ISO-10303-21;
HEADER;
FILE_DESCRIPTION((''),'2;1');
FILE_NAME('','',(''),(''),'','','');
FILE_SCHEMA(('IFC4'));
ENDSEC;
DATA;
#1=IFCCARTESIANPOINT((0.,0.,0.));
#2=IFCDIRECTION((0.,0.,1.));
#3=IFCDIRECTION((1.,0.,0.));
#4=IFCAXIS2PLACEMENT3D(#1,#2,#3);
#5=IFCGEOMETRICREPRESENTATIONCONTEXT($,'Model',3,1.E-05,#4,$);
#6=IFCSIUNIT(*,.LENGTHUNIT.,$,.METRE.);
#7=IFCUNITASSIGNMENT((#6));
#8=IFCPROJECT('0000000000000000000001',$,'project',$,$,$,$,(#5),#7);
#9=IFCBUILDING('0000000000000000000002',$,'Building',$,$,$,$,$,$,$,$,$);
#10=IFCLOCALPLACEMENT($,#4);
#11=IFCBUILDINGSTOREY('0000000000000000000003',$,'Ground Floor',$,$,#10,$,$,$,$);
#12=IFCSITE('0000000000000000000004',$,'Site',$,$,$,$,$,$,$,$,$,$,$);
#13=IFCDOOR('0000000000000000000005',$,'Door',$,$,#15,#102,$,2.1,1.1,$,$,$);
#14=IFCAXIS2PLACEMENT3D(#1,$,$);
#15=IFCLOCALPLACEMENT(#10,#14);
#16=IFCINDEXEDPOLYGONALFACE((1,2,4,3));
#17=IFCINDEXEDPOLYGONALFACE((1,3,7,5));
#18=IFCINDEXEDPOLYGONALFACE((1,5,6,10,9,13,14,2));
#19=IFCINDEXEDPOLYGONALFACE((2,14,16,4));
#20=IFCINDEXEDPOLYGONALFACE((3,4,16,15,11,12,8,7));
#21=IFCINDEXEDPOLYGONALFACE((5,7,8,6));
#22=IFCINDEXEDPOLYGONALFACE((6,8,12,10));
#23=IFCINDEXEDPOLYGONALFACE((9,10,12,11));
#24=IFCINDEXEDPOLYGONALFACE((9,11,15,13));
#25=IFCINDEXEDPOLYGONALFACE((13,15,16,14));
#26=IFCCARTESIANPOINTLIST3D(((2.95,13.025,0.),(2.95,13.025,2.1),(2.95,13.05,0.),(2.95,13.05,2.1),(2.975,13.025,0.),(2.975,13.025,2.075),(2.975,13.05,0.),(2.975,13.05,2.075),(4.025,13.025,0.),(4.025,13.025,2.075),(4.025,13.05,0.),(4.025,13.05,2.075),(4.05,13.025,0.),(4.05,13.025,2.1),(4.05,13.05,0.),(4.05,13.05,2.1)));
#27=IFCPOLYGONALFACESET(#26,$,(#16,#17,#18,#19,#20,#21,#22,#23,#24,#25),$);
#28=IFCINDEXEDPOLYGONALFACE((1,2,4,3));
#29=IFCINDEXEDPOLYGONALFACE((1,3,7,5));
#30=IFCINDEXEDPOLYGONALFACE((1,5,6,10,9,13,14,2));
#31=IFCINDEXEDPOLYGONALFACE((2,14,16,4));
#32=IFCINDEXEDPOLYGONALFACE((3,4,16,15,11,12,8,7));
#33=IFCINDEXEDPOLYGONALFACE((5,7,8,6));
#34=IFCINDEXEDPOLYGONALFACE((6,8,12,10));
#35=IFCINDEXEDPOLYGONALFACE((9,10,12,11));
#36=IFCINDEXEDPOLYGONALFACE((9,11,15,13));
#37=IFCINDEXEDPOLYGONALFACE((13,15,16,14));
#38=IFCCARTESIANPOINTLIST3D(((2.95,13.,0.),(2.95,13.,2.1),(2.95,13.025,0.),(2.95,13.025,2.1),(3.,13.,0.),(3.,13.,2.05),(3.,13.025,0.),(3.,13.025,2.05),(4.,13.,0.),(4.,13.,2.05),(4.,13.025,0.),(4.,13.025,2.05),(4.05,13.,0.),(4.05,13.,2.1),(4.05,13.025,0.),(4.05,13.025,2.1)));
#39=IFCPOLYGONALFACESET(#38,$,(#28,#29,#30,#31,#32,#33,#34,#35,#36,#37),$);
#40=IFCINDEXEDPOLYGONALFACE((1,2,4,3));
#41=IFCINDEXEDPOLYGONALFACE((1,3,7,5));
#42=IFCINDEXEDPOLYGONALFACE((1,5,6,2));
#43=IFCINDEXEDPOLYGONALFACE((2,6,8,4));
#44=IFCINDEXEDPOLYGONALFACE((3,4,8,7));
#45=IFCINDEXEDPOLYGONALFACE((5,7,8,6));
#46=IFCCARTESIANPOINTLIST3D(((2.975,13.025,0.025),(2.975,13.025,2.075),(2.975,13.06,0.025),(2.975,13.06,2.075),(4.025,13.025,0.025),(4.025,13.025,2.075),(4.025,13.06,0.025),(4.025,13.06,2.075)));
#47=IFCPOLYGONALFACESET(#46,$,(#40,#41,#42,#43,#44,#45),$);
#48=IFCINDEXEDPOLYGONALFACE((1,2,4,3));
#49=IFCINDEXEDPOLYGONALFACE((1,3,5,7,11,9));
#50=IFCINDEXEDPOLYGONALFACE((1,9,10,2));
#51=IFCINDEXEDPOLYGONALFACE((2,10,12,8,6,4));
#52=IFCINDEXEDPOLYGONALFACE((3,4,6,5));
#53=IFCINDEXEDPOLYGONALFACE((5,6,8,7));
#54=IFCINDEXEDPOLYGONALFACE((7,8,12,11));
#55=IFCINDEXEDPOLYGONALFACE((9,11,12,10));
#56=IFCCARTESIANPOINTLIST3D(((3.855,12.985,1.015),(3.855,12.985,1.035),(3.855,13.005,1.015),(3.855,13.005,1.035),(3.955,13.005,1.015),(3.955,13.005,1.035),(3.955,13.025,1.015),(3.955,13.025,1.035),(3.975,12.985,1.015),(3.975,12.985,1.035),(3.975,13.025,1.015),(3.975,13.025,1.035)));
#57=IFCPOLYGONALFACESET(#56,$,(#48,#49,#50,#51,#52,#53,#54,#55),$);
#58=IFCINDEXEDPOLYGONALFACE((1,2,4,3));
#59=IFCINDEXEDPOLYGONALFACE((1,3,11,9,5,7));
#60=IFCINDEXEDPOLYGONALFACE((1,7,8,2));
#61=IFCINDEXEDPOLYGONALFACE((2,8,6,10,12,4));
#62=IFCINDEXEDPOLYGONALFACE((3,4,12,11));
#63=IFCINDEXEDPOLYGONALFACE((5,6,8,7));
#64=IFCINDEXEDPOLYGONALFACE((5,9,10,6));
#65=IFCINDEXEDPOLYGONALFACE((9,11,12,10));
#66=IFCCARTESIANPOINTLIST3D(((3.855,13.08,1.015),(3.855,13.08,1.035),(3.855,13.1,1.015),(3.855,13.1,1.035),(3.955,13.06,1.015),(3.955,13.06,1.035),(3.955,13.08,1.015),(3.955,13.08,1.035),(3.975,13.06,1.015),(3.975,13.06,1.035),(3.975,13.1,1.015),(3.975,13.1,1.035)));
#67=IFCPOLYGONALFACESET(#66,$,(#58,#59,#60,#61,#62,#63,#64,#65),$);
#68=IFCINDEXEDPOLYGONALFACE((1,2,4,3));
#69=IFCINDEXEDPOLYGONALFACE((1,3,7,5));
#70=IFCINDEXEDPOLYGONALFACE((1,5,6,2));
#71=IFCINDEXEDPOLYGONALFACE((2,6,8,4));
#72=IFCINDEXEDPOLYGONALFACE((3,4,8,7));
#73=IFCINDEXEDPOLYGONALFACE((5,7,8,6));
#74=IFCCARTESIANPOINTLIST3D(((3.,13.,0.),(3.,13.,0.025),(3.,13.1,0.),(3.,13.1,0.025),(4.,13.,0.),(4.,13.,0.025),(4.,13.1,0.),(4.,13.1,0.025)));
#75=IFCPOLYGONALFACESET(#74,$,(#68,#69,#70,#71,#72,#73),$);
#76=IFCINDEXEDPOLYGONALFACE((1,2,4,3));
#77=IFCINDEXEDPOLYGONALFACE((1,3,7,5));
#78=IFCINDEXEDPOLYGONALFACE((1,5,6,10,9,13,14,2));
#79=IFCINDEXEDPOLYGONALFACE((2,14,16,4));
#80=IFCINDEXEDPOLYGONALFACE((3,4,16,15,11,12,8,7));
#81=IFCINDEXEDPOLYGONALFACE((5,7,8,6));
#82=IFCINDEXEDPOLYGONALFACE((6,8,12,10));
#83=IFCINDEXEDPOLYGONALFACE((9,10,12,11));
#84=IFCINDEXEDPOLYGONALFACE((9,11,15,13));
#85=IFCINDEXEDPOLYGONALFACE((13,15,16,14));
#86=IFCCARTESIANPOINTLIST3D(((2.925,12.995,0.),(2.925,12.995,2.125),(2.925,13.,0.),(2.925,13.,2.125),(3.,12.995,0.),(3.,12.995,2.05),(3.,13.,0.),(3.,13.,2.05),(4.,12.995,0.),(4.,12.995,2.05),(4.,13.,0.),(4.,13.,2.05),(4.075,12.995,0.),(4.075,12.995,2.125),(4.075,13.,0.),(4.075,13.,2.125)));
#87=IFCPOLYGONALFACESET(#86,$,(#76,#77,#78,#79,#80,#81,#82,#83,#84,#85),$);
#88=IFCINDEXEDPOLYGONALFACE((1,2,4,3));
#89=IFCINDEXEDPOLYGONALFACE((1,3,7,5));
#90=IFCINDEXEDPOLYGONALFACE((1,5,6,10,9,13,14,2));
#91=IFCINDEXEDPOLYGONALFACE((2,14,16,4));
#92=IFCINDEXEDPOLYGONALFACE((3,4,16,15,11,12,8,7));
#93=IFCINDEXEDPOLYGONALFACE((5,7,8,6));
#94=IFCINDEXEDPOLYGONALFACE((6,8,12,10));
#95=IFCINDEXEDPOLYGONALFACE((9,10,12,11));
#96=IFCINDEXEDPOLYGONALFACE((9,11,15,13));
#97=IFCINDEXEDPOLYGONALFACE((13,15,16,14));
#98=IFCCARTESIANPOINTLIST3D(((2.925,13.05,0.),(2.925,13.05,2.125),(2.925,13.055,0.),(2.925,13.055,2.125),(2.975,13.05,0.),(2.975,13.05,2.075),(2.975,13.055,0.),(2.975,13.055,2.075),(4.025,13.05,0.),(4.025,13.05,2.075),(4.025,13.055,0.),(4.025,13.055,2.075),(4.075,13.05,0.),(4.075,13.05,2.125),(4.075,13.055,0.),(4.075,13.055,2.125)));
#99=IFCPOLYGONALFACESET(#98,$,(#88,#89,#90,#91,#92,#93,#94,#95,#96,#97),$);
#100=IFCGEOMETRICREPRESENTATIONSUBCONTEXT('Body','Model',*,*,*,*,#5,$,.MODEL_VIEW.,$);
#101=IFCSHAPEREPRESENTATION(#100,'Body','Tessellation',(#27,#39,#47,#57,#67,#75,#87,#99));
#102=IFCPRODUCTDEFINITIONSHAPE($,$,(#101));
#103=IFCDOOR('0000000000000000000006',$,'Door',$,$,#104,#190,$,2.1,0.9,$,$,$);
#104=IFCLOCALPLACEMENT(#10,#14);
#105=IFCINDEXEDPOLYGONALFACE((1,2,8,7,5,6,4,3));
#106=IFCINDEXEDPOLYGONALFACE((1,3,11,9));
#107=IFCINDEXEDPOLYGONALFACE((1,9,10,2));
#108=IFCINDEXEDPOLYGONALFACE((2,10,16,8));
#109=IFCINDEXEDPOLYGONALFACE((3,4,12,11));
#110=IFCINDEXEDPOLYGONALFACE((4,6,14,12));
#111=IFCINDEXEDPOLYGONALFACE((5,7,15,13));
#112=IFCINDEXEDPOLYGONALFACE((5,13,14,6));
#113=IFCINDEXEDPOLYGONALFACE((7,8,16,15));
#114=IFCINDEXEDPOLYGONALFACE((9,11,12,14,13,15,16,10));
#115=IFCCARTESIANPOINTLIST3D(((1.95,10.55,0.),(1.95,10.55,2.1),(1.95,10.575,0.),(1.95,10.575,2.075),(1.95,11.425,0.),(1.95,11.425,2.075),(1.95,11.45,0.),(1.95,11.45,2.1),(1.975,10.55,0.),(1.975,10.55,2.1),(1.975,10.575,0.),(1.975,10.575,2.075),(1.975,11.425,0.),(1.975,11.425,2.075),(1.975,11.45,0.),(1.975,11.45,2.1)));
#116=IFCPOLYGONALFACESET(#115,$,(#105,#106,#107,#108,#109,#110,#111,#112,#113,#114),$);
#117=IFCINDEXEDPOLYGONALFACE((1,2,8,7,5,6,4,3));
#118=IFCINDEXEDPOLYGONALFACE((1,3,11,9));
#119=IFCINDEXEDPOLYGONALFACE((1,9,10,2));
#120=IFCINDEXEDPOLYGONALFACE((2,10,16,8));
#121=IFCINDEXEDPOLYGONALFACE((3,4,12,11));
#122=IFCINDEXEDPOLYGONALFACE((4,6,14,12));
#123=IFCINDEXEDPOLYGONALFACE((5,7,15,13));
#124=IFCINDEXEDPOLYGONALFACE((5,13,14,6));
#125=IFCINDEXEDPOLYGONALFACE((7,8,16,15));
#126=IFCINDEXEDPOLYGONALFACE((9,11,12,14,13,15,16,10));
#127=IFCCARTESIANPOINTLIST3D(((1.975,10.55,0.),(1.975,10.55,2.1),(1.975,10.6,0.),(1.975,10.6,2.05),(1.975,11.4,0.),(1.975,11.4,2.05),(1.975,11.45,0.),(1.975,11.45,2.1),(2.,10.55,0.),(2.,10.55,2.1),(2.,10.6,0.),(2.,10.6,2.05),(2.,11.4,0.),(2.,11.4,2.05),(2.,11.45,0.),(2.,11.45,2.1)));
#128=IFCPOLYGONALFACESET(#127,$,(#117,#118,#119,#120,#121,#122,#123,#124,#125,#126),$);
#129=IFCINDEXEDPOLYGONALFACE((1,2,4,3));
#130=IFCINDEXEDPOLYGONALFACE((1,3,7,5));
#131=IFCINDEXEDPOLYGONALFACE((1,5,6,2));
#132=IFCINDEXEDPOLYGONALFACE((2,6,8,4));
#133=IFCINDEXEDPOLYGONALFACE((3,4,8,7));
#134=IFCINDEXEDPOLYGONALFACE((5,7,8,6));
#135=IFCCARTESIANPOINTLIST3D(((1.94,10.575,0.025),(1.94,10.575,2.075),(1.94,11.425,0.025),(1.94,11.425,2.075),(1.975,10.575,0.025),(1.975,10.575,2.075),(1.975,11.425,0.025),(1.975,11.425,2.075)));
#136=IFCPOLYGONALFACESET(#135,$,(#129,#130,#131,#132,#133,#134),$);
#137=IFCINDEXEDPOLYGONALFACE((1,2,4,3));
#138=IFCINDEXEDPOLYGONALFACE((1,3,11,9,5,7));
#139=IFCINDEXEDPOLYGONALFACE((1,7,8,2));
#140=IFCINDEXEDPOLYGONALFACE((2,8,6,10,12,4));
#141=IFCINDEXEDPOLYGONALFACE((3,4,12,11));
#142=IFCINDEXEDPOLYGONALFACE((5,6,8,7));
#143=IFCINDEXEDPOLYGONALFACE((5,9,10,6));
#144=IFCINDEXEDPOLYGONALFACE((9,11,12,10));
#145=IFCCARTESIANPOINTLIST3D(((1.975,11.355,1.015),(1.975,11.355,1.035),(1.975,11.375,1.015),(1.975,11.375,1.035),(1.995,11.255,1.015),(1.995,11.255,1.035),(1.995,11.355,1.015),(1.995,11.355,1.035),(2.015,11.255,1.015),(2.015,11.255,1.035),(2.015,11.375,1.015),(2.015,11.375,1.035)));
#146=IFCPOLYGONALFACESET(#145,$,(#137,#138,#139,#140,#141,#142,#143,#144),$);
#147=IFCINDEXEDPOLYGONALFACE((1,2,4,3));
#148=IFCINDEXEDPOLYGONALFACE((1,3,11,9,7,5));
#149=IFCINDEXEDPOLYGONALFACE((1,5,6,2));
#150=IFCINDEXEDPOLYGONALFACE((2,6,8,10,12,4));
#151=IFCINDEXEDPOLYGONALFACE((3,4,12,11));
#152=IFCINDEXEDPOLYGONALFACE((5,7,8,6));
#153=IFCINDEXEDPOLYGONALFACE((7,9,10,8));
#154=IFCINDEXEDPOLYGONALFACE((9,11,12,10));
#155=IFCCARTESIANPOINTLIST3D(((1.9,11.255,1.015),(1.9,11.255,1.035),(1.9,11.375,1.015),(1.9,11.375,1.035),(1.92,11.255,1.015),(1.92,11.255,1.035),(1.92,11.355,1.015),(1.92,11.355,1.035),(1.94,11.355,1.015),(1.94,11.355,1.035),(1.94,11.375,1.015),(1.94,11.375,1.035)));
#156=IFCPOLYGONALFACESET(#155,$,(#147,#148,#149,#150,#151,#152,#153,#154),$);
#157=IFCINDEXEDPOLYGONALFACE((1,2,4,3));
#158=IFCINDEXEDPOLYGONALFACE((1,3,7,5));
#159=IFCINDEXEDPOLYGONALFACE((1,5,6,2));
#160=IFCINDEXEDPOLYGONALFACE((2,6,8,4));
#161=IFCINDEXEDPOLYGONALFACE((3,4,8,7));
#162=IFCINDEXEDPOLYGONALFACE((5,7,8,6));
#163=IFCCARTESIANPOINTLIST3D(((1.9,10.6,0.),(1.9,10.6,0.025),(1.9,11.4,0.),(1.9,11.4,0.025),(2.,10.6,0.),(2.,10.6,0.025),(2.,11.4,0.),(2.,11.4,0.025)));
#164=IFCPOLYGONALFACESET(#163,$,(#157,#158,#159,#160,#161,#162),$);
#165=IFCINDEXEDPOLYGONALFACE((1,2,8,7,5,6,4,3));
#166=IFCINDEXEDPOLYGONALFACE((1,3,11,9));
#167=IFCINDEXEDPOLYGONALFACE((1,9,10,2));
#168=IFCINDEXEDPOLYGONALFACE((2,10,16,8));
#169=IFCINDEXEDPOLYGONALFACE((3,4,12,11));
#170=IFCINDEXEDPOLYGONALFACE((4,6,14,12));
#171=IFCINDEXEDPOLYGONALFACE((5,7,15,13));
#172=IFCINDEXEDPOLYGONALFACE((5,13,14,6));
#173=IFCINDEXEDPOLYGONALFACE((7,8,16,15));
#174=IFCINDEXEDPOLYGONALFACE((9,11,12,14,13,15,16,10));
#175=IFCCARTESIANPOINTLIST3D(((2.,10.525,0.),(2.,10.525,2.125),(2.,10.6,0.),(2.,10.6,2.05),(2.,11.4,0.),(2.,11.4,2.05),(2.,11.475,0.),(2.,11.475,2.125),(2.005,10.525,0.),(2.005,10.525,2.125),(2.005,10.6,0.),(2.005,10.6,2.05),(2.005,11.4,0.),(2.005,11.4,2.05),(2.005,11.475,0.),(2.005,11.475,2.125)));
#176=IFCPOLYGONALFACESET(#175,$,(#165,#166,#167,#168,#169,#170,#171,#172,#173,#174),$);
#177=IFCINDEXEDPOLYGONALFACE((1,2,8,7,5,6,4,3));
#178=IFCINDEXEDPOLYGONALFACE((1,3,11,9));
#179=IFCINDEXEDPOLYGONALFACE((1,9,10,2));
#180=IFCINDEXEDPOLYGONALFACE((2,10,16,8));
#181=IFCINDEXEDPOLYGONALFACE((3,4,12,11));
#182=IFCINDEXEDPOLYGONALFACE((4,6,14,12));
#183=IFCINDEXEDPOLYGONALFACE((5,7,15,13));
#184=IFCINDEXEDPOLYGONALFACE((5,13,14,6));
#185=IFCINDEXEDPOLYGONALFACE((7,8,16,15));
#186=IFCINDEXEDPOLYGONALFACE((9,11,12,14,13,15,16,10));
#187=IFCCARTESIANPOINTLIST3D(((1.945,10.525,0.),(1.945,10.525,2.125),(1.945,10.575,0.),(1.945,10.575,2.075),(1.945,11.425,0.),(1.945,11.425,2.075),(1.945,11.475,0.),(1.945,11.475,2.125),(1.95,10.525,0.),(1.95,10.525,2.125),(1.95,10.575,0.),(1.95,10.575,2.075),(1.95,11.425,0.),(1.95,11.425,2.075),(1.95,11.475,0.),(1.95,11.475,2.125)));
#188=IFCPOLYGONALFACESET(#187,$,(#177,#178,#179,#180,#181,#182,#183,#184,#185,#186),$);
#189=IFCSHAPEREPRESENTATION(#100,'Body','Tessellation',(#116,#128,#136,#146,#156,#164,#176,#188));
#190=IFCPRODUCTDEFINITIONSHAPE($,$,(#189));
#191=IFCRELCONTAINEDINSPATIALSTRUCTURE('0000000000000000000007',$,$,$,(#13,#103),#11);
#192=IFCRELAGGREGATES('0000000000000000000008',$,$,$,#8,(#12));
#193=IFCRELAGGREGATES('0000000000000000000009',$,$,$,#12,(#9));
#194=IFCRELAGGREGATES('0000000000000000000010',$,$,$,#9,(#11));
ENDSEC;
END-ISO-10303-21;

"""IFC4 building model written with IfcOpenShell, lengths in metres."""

from ifc_helpers import new_model, si_unit, frame, origin_with_axes, place, context, subcontext, project, spatial, line, indexed_curve, outline, extrude, element, save


model = new_model("IFC4")

# Units and contexts
model_context = context("Model", 3, precision=1e-05, world=origin_with_axes())
body_context = subcontext(model_context, "Body", "Model", "MODEL_VIEW")
ifc_project = project(units=[si_unit("LENGTHUNIT", "METRE")], contexts=[model_context])

# Site, building, storey
site = spatial("IfcSite", under=ifc_project, Name="Site")
building = spatial("IfcBuilding", under=site, Name="Building")
storey_placement = place(None, origin_with_axes())
storey = spatial("IfcBuildingStorey", under=building, at=storey_placement, Name="Ground Floor")

# Doors
door_1_placement = place(storey_placement, frame((2.95, 13.0, 0.0), z_axis=(0.0, 0.0, 1.0), x_axis=(1.0, 0.0, 0.0)))
element("IfcDoor", 1, at=door_1_placement, inside=storey, Name="Door", OverallHeight=2.1, OverallWidth=1.1, context=body_context, shape_type="SweptSolid", body=[
    extrude(outline(indexed_curve([(0.0, 0.0), (0.0, 2.1), (1.1, 2.1), (1.1, 0.0), (1.075, 0.0), (1.075, 2.075), (0.025, 2.075), (0.025, 0.0)], segments=[line(1, 2, 3, 4, 5, 6, 7, 8, 1)])), frame((0.0, 0.025, 0.0), z_axis=(0.0, -1.0, 0.0), x_axis=(1.0, 0.0, 0.0)), (0.0, 0.0, -1.0), 0.025),
    extrude(outline(indexed_curve([(0.0, 0.0), (0.0, 2.1), (1.1, 2.1), (1.1, 0.0), (1.05, 0.0), (1.05, 2.05), (0.05, 2.05), (0.05, 0.0)], segments=[line(1, 2, 3, 4, 5, 6, 7, 8, 1)])), frame((0.0, 0.0, 0.0), z_axis=(0.0, -1.0, 0.0), x_axis=(1.0, 0.0, 0.0)), (0.0, 0.0, -1.0), 0.025),
    extrude(outline(indexed_curve([(0.0, 0.0), (1.05, 0.0), (1.05, 0.035), (0.0, 0.035)], segments=[line(1, 2, 3, 4, 1)])), frame((0.025, 0.025, 0.025), z_axis=(0.0, 0.0, 1.0), x_axis=(1.0, 0.0, 0.0)), (0.0, 0.0, 1.0), 2.05),
    extrude(outline(indexed_curve([(0.0, 0.0), (0.0, -0.04), (-0.12, -0.04), (-0.12, -0.02), (-0.02, -0.02), (-0.02, 0.0)], segments=[line(1, 2, 3, 4, 5, 6, 1)])), frame((1.025, 0.025, 1.015), z_axis=(0.0, 0.0, 1.0), x_axis=(1.0, 0.0, 0.0)), (0.0, 0.0, 1.0), 0.02),
    extrude(outline(indexed_curve([(0.0, 0.0), (0.0, 0.04), (-0.12, 0.04), (-0.12, 0.02), (-0.02, 0.02), (-0.02, 0.0)], segments=[line(1, 2, 3, 4, 5, 6, 1)])), frame((1.025, 0.06, 1.015), z_axis=(0.0, 0.0, 1.0), x_axis=(1.0, 0.0, 0.0)), (0.0, 0.0, 1.0), 0.02),
    extrude(outline(indexed_curve([(0.0, 0.0), (1.0, 0.0), (1.0, 0.1), (0.0, 0.1)], segments=[line(1, 2, 3, 4, 1)])), frame((0.05, 0.0, 0.0), z_axis=(0.0, 0.0, 1.0), x_axis=(1.0, 0.0, 0.0)), (0.0, 0.0, 1.0), 0.025),
    extrude(outline(indexed_curve([(0.0, 0.0), (0.0, 2.125), (1.15, 2.125), (1.15, 0.0), (1.075, 0.0), (1.075, 2.05), (0.075, 2.05), (0.075, 0.0)], segments=[line(1, 2, 3, 4, 5, 6, 7, 8, 1)])), frame((-0.025, -0.005, 0.0), z_axis=(0.0, -1.0, 0.0), x_axis=(1.0, 0.0, 0.0)), (0.0, 0.0, -1.0), 0.005),
    extrude(outline(indexed_curve([(0.0, 0.0), (0.0, 2.125), (1.15, 2.125), (1.15, 0.0), (1.1, 0.0), (1.1, 2.075), (0.05, 2.075), (0.05, 0.0)], segments=[line(1, 2, 3, 4, 5, 6, 7, 8, 1)])), frame((-0.025, 0.05, 0.0), z_axis=(0.0, -1.0, 0.0), x_axis=(1.0, 0.0, 0.0)), (0.0, 0.0, -1.0), 0.005),
])
door_2_placement = place(storey_placement, frame((2.0, 10.55, 0.0), z_axis=(0.0, 0.0, 1.0), x_axis=(0.0, 1.0, 0.0)))
element("IfcDoor", 2, at=door_2_placement, inside=storey, Name="Door", OverallHeight=2.1, OverallWidth=0.9, context=body_context, shape_type="SweptSolid", body=[
    extrude(outline(indexed_curve([(0.0, 0.0), (0.0, 2.1), (0.9, 2.1), (0.9, 0.0), (0.875, 0.0), (0.875, 2.075), (0.025, 2.075), (0.025, 0.0)], segments=[line(1, 2, 3, 4, 5, 6, 7, 8, 1)])), frame((0.0, 0.025, 0.0), z_axis=(0.0, -1.0, 0.0), x_axis=(1.0, 0.0, 0.0)), (0.0, 0.0, -1.0), 0.025),
    extrude(outline(indexed_curve([(0.0, 0.0), (0.0, 2.1), (0.9, 2.1), (0.9, 0.0), (0.85, 0.0), (0.85, 2.05), (0.05, 2.05), (0.05, 0.0)], segments=[line(1, 2, 3, 4, 5, 6, 7, 8, 1)])), frame((0.0, 0.0, 0.0), z_axis=(0.0, -1.0, 0.0), x_axis=(1.0, 0.0, 0.0)), (0.0, 0.0, -1.0), 0.025),
    extrude(outline(indexed_curve([(0.0, 0.0), (0.85, 0.0), (0.85, 0.035), (0.0, 0.035)], segments=[line(1, 2, 3, 4, 1)])), frame((0.025, 0.025, 0.025), z_axis=(0.0, 0.0, 1.0), x_axis=(1.0, 0.0, 0.0)), (0.0, 0.0, 1.0), 2.05),
    extrude(outline(indexed_curve([(0.0, 0.0), (0.0, -0.04), (-0.12, -0.04), (-0.12, -0.02), (-0.02, -0.02), (-0.02, 0.0)], segments=[line(1, 2, 3, 4, 5, 6, 1)])), frame((0.825, 0.025, 1.015), z_axis=(0.0, 0.0, 1.0), x_axis=(1.0, 0.0, 0.0)), (0.0, 0.0, 1.0), 0.02),
    extrude(outline(indexed_curve([(0.0, 0.0), (0.0, 0.04), (-0.12, 0.04), (-0.12, 0.02), (-0.02, 0.02), (-0.02, 0.0)], segments=[line(1, 2, 3, 4, 5, 6, 1)])), frame((0.825, 0.06, 1.015), z_axis=(0.0, 0.0, 1.0), x_axis=(1.0, 0.0, 0.0)), (0.0, 0.0, 1.0), 0.02),
    extrude(outline(indexed_curve([(0.0, 0.0), (0.8, 0.0), (0.8, 0.1), (0.0, 0.1)], segments=[line(1, 2, 3, 4, 1)])), frame((0.05, 0.0, 0.0), z_axis=(0.0, 0.0, 1.0), x_axis=(1.0, 0.0, 0.0)), (0.0, 0.0, 1.0), 0.025),
    extrude(outline(indexed_curve([(0.0, 0.0), (0.0, 2.125), (0.95, 2.125), (0.95, 0.0), (0.875, 0.0), (0.875, 2.05), (0.075, 2.05), (0.075, 0.0)], segments=[line(1, 2, 3, 4, 5, 6, 7, 8, 1)])), frame((-0.025, -0.005, 0.0), z_axis=(0.0, -1.0, 0.0), x_axis=(1.0, 0.0, 0.0)), (0.0, 0.0, -1.0), 0.005),
    extrude(outline(indexed_curve([(0.0, 0.0), (0.0, 2.125), (0.95, 2.125), (0.95, 0.0), (0.9, 0.0), (0.9, 2.075), (0.05, 2.075), (0.05, 0.0)], segments=[line(1, 2, 3, 4, 5, 6, 7, 8, 1)])), frame((-0.025, 0.05, 0.0), z_axis=(0.0, -1.0, 0.0), x_axis=(1.0, 0.0, 0.0)), (0.0, 0.0, -1.0), 0.005),
])

save(model, "model.ifc")
